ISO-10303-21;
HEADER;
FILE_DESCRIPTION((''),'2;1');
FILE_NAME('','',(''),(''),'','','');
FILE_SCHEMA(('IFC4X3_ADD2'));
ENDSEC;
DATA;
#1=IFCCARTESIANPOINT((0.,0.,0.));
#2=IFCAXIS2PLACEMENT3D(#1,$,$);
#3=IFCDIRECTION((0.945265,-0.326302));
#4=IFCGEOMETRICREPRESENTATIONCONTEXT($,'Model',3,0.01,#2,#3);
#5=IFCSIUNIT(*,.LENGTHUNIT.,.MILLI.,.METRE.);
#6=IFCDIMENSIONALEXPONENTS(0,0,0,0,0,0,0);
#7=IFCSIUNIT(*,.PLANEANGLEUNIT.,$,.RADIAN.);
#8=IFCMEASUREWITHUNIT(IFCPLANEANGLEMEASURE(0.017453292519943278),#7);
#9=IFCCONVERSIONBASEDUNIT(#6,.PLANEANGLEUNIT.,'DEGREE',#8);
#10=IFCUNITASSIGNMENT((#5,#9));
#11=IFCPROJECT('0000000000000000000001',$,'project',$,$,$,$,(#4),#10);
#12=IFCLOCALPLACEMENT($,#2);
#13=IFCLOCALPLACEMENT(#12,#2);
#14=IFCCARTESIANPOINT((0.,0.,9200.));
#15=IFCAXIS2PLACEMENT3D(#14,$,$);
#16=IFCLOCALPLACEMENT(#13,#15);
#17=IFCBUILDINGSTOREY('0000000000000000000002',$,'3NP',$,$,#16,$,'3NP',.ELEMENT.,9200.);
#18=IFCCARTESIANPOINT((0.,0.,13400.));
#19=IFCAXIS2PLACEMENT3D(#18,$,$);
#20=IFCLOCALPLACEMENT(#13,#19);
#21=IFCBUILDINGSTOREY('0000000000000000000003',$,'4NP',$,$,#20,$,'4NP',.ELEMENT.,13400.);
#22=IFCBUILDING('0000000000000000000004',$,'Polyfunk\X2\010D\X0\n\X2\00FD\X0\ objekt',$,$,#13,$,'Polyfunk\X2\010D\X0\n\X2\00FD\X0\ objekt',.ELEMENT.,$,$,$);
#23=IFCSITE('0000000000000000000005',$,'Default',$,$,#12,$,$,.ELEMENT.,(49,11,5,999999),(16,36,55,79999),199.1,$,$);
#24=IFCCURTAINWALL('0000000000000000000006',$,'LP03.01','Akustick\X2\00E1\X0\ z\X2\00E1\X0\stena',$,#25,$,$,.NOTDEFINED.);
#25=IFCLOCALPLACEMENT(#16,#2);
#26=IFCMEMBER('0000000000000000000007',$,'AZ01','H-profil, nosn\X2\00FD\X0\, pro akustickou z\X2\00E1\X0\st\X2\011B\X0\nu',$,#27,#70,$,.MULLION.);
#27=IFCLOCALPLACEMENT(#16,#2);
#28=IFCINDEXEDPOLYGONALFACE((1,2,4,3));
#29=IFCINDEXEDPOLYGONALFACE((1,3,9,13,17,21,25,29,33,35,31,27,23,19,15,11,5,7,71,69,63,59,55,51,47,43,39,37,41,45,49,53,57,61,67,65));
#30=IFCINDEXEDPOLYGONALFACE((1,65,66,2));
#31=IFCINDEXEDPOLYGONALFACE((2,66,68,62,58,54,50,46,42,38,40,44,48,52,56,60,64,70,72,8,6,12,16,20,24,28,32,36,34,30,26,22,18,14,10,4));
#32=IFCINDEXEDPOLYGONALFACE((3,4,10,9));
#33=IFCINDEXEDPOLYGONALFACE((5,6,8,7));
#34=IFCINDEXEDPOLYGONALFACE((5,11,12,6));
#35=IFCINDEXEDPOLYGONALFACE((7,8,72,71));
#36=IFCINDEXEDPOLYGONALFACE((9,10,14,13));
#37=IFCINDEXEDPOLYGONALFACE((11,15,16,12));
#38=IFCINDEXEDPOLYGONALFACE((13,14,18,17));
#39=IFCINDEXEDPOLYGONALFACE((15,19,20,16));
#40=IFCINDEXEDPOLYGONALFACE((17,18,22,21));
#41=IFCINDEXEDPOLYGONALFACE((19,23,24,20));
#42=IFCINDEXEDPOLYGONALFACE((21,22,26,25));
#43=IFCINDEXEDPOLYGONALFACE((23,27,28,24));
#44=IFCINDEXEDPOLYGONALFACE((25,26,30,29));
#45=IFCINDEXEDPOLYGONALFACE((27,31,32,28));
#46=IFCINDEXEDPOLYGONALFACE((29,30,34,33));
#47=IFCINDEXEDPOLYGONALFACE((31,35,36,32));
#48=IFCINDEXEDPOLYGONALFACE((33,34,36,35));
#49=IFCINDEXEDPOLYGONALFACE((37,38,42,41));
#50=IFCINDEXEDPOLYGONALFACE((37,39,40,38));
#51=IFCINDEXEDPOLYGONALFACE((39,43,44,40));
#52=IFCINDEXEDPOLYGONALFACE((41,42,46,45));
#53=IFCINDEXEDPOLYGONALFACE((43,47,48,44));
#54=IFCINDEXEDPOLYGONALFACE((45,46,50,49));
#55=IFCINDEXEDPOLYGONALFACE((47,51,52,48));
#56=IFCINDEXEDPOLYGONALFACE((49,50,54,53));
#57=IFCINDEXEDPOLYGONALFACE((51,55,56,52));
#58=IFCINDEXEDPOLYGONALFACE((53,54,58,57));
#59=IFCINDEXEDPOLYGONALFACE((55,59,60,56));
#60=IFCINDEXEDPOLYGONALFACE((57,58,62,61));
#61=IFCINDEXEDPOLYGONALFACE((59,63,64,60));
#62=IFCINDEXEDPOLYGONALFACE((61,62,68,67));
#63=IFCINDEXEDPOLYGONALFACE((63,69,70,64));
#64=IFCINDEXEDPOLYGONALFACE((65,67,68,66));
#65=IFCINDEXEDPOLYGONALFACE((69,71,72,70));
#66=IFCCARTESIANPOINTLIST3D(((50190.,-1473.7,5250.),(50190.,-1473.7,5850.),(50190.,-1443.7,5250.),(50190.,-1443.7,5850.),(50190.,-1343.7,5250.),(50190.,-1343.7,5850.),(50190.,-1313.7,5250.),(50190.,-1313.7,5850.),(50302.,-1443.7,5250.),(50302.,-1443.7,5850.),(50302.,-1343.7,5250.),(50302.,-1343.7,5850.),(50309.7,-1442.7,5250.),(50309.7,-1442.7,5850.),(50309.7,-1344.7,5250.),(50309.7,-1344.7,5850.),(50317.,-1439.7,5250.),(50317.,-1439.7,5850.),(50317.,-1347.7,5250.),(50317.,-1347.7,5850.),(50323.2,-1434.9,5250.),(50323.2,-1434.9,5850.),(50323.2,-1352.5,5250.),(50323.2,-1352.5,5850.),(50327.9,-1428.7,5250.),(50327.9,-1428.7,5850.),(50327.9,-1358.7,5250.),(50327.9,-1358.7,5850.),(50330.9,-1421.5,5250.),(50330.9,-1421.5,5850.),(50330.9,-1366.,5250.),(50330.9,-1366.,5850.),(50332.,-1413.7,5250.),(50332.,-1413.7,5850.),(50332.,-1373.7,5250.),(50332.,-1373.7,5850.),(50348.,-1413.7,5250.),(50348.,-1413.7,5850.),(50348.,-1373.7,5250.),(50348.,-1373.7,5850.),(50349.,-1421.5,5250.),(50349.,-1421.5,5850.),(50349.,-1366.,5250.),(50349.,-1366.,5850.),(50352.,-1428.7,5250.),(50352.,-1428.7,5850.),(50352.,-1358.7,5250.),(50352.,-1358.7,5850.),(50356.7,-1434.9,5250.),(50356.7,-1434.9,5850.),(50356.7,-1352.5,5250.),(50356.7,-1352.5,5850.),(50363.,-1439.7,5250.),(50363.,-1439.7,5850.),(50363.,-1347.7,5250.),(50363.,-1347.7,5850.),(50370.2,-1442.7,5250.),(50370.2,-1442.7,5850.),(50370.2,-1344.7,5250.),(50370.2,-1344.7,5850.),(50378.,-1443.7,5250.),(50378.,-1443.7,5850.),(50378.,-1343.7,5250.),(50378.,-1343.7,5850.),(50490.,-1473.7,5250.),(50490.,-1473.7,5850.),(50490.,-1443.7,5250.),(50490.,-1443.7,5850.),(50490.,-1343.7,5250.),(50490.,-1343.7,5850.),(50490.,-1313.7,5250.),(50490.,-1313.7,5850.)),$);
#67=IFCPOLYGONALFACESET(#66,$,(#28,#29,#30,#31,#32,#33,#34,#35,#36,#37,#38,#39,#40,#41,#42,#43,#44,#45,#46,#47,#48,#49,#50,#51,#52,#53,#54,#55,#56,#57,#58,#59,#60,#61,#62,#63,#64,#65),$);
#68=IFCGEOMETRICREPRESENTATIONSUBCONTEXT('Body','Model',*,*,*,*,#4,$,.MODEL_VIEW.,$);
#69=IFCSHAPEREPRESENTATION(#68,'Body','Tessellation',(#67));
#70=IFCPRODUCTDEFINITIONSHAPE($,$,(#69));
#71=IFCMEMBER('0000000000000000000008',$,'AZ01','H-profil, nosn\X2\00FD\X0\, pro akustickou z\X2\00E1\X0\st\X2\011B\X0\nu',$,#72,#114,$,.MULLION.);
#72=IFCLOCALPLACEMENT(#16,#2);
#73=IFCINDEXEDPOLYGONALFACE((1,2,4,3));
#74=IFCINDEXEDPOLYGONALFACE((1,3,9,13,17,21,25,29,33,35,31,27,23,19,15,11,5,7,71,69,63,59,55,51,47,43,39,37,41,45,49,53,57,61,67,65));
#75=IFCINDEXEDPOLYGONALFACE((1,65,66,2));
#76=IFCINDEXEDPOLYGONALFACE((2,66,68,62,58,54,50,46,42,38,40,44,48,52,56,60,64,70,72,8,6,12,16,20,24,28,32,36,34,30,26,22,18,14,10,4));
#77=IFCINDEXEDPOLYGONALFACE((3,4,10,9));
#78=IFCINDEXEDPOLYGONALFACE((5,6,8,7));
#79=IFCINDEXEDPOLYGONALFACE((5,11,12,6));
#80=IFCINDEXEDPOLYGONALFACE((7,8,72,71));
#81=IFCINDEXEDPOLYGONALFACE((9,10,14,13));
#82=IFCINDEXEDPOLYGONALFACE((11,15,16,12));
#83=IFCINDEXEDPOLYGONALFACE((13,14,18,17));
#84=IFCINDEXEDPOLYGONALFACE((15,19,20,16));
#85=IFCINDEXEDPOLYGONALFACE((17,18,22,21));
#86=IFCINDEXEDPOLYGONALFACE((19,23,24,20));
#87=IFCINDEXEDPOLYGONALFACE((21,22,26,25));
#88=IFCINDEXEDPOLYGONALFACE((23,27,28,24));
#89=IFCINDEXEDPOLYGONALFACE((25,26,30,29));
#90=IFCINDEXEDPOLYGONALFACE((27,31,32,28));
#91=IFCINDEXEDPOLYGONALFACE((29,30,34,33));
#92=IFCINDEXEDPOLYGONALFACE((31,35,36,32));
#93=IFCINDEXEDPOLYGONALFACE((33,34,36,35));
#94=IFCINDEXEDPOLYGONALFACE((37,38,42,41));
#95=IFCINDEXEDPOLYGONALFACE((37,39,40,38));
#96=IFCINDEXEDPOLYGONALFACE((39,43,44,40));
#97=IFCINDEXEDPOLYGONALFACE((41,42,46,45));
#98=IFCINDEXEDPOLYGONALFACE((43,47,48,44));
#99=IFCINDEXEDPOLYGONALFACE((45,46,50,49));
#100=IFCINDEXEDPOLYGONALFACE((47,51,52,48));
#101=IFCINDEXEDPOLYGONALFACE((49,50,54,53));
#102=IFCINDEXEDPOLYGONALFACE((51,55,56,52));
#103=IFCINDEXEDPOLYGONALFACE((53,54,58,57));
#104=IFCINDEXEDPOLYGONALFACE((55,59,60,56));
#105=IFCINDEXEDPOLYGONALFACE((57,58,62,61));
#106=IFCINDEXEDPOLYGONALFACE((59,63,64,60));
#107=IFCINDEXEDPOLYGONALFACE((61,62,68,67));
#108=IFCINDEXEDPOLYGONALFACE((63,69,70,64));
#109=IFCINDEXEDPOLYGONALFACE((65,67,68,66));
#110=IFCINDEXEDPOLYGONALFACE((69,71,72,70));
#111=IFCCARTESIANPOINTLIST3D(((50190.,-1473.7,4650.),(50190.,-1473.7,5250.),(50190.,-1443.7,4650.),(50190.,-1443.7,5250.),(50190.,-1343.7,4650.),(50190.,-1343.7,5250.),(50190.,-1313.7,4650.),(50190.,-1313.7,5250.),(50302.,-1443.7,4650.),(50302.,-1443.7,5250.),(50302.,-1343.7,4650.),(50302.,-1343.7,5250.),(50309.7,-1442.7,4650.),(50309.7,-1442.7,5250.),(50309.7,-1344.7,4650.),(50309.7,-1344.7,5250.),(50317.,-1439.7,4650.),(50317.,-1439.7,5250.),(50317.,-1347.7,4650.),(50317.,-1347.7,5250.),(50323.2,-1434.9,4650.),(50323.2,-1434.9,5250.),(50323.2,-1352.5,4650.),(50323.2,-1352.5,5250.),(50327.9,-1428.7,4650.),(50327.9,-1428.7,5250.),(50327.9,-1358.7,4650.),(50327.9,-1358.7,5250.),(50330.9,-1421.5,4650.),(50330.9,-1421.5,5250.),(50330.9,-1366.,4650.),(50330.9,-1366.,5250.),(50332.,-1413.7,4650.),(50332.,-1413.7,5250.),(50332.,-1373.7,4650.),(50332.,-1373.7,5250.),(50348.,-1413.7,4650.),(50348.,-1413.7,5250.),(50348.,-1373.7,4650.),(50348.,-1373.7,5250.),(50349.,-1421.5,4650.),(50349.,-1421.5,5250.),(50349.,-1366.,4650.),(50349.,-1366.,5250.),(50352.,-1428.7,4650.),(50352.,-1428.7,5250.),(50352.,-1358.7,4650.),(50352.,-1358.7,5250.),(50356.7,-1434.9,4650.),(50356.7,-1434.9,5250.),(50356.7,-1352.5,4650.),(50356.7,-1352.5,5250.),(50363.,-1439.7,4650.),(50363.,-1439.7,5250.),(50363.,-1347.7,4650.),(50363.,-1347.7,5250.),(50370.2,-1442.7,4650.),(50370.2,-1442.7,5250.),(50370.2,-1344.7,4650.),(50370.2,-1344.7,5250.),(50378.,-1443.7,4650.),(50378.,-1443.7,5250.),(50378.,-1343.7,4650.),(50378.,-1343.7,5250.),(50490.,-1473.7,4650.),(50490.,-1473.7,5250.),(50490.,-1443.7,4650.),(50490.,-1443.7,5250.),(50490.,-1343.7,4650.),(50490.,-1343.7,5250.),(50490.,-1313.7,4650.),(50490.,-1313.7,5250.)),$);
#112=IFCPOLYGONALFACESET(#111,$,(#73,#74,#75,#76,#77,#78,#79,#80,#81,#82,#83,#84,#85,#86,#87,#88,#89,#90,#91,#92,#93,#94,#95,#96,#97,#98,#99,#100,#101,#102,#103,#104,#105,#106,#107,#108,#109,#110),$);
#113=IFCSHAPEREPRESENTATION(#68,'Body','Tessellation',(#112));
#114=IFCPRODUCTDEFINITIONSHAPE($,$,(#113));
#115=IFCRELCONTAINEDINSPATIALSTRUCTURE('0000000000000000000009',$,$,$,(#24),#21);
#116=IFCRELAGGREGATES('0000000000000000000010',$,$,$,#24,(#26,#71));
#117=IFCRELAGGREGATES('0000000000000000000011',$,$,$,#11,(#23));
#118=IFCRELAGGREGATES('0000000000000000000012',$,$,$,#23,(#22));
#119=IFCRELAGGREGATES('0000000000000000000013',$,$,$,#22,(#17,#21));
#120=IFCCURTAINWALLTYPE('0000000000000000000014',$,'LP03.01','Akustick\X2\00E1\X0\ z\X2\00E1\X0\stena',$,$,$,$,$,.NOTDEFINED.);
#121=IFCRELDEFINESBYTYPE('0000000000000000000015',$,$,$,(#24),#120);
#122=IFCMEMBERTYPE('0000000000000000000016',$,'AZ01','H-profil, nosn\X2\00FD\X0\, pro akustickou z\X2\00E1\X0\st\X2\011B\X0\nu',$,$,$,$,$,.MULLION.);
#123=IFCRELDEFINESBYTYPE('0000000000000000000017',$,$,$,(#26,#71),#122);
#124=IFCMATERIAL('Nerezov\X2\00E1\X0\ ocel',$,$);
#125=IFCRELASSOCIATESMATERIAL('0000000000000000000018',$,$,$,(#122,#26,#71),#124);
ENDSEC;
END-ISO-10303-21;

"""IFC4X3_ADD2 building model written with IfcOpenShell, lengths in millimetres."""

from ifc_helpers import new_model, entity, si_unit, converted_unit, direction, frame, frame_2d, origin, place, context, subcontext, project, spatial, polyline, circle_curve, parameter, trimmed, segment, composite_curve, outline, extrude, source, transform, mapped, material, material_profile, profile_set, profile_usage, type_object, element, aggregate, save


model = new_model("IFC4X3_ADD2")

# Units and contexts
model_context = context("Model", 3, precision=0.01, world=origin(), true_north=direction((0.945265, -0.326302)))
body_context = subcontext(model_context, "Body", "Model", "MODEL_VIEW")
ifc_project = project(units=[si_unit("LENGTHUNIT", "METRE", prefix="MILLI"), converted_unit("PLANEANGLEUNIT", "DEGREE", entity("IfcPlaneAngleMeasure", 0.017453292519943278), si_unit("PLANEANGLEUNIT", "RADIAN"), dimensions=[0, 0, 0, 0, 0, 0, 0])], contexts=[model_context])

# Site, building, storey
site_placement = place(None, origin())
site = spatial("IfcSite", under=ifc_project, at=site_placement, Name="Default", CompositionType="ELEMENT", RefLatitude=(49, 11, 5, 999999), RefLongitude=(16, 36, 55, 79999), RefElevation=199.1)
building_placement = place(site_placement, origin())
building = spatial("IfcBuilding", under=site, at=building_placement, Name="Polyfunkčný objekt", LongName="Polyfunkčný objekt", CompositionType="ELEMENT")
storey_1_placement = place(building_placement, frame((0.0, 0.0, 9200.0)))
storey_1 = spatial("IfcBuildingStorey", under=building, at=storey_1_placement, Name="3NP", LongName="3NP", CompositionType="ELEMENT", Elevation=9200.0)

# Shared definitions
storey_2_placement = place(building_placement, frame((0.0, 0.0, 13400.0)))
storey_2 = spatial("IfcBuildingStorey", under=building, at=storey_2_placement, Name="4NP", LongName="4NP", CompositionType="ELEMENT", Elevation=13400.0)

# Curtain wall, members
curtain_wall_type_1 = type_object("IfcCurtainWallType", Name="LP03.01", Description="Akustická zástena", PredefinedType="NOTDEFINED")
ifc_material_1 = material(Name="Nerezová ocel")
ifc_material_profile_1 = material_profile(ifc_material_1, outline(composite_curve([segment(polyline([(50.0, -150.0), (80.0, -150.0)]), True, "CONTINUOUS"), segment(polyline([(80.0, -150.0), (80.0, 150.0)]), True, "CONTINUOUS"), segment(polyline([(80.0, 150.0), (50.0, 150.0)]), True, "CONTINUOUS"), segment(polyline([(50.0, 150.0), (50.0, 38.0)]), True, "CONTINUOUS"), segment(trimmed(circle_curve(frame_2d((20.0, 38.0), x_axis=(0.0, 1.0)), 30.0), [parameter(180.0)], [parameter(270.0)], True, "PARAMETER"), False, "CONTINUOUS"), segment(polyline([(20.0, 8.0), (-20.0, 8.0)]), True, "CONTINUOUS"), segment(trimmed(circle_curve(frame_2d((-20.0, 38.0), x_axis=(0.0, 1.0)), 30.0), [parameter(90.0)], [parameter(180.0)], True, "PARAMETER"), False, "CONTINUOUS"), segment(polyline([(-50.0, 38.0), (-50.0, 150.0)]), True, "CONTINUOUS"), segment(polyline([(-50.0, 150.0), (-80.0, 150.0)]), True, "CONTINUOUS"), segment(polyline([(-80.0, 150.0), (-80.0, -150.0)]), True, "CONTINUOUS"), segment(polyline([(-80.0, -150.0), (-50.0, -150.0)]), True, "CONTINUOUS"), segment(polyline([(-50.0, -150.0), (-50.0, -38.0)]), True, "CONTINUOUS"), segment(trimmed(circle_curve(frame_2d((-20.0, -38.0), x_axis=(0.0, 1.0)), 30.0), [parameter(0.0)], [parameter(90.0)], True, "PARAMETER"), False, "CONTINUOUS"), segment(polyline([(-20.0, -8.0), (20.0, -8.0)]), True, "CONTINUOUS"), segment(trimmed(circle_curve(frame_2d((20.0, -38.0), x_axis=(0.0, 1.0)), 30.0), [parameter(270.0)], [parameter(0.0)], True, "PARAMETER"), False, "CONTINUOUS"), segment(polyline([(50.0, -38.0), (50.0, -150.0)]), True, "CONTINUOUS")], self_intersect=False)), Name="Profil zástena")
ifc_profile_set_1 = profile_set([ifc_material_profile_1], Name="Profil zástena")
ifc_profile_usage_1 = profile_usage(ifc_profile_set_1)
member_type_1 = type_object("IfcMemberType", Name="AZ01", Description="H-profil, nosný, pro akustickou zástěnu", PredefinedType="MULLION", material=ifc_profile_set_1)
shared_shape_1 = source(origin(), body_context, "Body", "SweptSolid", [
    extrude(outline(composite_curve([segment(polyline([(-150.0, -50.0), (-150.0, -80.0)]), True, "CONTINUOUS"), segment(polyline([(-150.0, -80.0), (150.0, -80.0)]), True, "CONTINUOUS"), segment(polyline([(150.0, -80.0), (150.0, -50.0)]), True, "CONTINUOUS"), segment(polyline([(150.0, -50.0), (38.0, -50.0)]), True, "CONTINUOUS"), segment(trimmed(circle_curve(frame_2d((38.0, -20.0), x_axis=(1.0, 0.0)), 30.0), [parameter(180.0)], [parameter(270.0)], True, "PARAMETER"), False, "CONTINUOUS"), segment(polyline([(8.0, -20.0), (8.0, 20.0)]), True, "CONTINUOUS"), segment(trimmed(circle_curve(frame_2d((38.0, 20.0), x_axis=(1.0, 0.0)), 30.0), [parameter(90.0)], [parameter(180.0)], True, "PARAMETER"), False, "CONTINUOUS"), segment(polyline([(38.0, 50.0), (150.0, 50.0)]), True, "CONTINUOUS"), segment(polyline([(150.0, 50.0), (150.0, 80.0)]), True, "CONTINUOUS"), segment(polyline([(150.0, 80.0), (-150.0, 80.0)]), True, "CONTINUOUS"), segment(polyline([(-150.0, 80.0), (-150.0, 50.0)]), True, "CONTINUOUS"), segment(polyline([(-150.0, 50.0), (-38.0, 50.0)]), True, "CONTINUOUS"), segment(trimmed(circle_curve(frame_2d((-38.0, 20.0), x_axis=(1.0, 0.0)), 30.0), [parameter(0.0)], [parameter(90.0)], True, "PARAMETER"), False, "CONTINUOUS"), segment(polyline([(-8.0, 20.0), (-8.0, -20.0)]), True, "CONTINUOUS"), segment(trimmed(circle_curve(frame_2d((-38.0, -20.0), x_axis=(1.0, 0.0)), 30.0), [parameter(270.0)], [parameter(0.0)], True, "PARAMETER"), False, "CONTINUOUS"), segment(polyline([(-38.0, -50.0), (-150.0, -50.0)]), True, "CONTINUOUS")], self_intersect=False)), frame((-150.0, 0.0, -600.0), z_axis=(0.0, 0.0, -1.0), x_axis=(-1.0, 0.0, 0.0)), (0.0, 0.0, -1.0), 600.0),
])
curtain_wall_1_placement = place(storey_2_placement, frame((0.0, 0.0, -13400.0)))
curtain_wall_1 = element("IfcCurtainWall", 1, at=curtain_wall_1_placement, inside=storey_2, type_object=curtain_wall_type_1, Name="LP03.01", Description="Akustická zástena", PredefinedType="NOTDEFINED")
member_1_placement = place(curtain_wall_1_placement, frame((50190.0, -1393.7, 15050.0), z_axis=(0.0, 0.0, 1.0), x_axis=(-1.0, 0.0, 0.0)))
member_1 = element("IfcMember", 2, at=member_1_placement, type_object=member_type_1, material=ifc_profile_usage_1, Name="AZ01", Description="H-profil, nosný, pro akustickou zástěnu", PredefinedType="MULLION", context=body_context, shape_type="MappedRepresentation", body=[
    mapped(shared_shape_1, transform((0.0, 0.0, 0.0), scale=1.0)),
])
member_2_placement = place(curtain_wall_1_placement, frame((50190.0, -1393.7, 14450.0), z_axis=(0.0, 0.0, 1.0), x_axis=(-1.0, 0.0, 0.0)))
member_2 = element("IfcMember", 3, at=member_2_placement, type_object=member_type_1, material=ifc_profile_usage_1, Name="AZ01", Description="H-profil, nosný, pro akustickou zástěnu", PredefinedType="MULLION", context=body_context, shape_type="MappedRepresentation", body=[
    mapped(shared_shape_1, transform((0.0, 0.0, 0.0), scale=1.0)),
])

aggregate(curtain_wall_1, [member_1, member_2])

save(model, "model.ifc")
